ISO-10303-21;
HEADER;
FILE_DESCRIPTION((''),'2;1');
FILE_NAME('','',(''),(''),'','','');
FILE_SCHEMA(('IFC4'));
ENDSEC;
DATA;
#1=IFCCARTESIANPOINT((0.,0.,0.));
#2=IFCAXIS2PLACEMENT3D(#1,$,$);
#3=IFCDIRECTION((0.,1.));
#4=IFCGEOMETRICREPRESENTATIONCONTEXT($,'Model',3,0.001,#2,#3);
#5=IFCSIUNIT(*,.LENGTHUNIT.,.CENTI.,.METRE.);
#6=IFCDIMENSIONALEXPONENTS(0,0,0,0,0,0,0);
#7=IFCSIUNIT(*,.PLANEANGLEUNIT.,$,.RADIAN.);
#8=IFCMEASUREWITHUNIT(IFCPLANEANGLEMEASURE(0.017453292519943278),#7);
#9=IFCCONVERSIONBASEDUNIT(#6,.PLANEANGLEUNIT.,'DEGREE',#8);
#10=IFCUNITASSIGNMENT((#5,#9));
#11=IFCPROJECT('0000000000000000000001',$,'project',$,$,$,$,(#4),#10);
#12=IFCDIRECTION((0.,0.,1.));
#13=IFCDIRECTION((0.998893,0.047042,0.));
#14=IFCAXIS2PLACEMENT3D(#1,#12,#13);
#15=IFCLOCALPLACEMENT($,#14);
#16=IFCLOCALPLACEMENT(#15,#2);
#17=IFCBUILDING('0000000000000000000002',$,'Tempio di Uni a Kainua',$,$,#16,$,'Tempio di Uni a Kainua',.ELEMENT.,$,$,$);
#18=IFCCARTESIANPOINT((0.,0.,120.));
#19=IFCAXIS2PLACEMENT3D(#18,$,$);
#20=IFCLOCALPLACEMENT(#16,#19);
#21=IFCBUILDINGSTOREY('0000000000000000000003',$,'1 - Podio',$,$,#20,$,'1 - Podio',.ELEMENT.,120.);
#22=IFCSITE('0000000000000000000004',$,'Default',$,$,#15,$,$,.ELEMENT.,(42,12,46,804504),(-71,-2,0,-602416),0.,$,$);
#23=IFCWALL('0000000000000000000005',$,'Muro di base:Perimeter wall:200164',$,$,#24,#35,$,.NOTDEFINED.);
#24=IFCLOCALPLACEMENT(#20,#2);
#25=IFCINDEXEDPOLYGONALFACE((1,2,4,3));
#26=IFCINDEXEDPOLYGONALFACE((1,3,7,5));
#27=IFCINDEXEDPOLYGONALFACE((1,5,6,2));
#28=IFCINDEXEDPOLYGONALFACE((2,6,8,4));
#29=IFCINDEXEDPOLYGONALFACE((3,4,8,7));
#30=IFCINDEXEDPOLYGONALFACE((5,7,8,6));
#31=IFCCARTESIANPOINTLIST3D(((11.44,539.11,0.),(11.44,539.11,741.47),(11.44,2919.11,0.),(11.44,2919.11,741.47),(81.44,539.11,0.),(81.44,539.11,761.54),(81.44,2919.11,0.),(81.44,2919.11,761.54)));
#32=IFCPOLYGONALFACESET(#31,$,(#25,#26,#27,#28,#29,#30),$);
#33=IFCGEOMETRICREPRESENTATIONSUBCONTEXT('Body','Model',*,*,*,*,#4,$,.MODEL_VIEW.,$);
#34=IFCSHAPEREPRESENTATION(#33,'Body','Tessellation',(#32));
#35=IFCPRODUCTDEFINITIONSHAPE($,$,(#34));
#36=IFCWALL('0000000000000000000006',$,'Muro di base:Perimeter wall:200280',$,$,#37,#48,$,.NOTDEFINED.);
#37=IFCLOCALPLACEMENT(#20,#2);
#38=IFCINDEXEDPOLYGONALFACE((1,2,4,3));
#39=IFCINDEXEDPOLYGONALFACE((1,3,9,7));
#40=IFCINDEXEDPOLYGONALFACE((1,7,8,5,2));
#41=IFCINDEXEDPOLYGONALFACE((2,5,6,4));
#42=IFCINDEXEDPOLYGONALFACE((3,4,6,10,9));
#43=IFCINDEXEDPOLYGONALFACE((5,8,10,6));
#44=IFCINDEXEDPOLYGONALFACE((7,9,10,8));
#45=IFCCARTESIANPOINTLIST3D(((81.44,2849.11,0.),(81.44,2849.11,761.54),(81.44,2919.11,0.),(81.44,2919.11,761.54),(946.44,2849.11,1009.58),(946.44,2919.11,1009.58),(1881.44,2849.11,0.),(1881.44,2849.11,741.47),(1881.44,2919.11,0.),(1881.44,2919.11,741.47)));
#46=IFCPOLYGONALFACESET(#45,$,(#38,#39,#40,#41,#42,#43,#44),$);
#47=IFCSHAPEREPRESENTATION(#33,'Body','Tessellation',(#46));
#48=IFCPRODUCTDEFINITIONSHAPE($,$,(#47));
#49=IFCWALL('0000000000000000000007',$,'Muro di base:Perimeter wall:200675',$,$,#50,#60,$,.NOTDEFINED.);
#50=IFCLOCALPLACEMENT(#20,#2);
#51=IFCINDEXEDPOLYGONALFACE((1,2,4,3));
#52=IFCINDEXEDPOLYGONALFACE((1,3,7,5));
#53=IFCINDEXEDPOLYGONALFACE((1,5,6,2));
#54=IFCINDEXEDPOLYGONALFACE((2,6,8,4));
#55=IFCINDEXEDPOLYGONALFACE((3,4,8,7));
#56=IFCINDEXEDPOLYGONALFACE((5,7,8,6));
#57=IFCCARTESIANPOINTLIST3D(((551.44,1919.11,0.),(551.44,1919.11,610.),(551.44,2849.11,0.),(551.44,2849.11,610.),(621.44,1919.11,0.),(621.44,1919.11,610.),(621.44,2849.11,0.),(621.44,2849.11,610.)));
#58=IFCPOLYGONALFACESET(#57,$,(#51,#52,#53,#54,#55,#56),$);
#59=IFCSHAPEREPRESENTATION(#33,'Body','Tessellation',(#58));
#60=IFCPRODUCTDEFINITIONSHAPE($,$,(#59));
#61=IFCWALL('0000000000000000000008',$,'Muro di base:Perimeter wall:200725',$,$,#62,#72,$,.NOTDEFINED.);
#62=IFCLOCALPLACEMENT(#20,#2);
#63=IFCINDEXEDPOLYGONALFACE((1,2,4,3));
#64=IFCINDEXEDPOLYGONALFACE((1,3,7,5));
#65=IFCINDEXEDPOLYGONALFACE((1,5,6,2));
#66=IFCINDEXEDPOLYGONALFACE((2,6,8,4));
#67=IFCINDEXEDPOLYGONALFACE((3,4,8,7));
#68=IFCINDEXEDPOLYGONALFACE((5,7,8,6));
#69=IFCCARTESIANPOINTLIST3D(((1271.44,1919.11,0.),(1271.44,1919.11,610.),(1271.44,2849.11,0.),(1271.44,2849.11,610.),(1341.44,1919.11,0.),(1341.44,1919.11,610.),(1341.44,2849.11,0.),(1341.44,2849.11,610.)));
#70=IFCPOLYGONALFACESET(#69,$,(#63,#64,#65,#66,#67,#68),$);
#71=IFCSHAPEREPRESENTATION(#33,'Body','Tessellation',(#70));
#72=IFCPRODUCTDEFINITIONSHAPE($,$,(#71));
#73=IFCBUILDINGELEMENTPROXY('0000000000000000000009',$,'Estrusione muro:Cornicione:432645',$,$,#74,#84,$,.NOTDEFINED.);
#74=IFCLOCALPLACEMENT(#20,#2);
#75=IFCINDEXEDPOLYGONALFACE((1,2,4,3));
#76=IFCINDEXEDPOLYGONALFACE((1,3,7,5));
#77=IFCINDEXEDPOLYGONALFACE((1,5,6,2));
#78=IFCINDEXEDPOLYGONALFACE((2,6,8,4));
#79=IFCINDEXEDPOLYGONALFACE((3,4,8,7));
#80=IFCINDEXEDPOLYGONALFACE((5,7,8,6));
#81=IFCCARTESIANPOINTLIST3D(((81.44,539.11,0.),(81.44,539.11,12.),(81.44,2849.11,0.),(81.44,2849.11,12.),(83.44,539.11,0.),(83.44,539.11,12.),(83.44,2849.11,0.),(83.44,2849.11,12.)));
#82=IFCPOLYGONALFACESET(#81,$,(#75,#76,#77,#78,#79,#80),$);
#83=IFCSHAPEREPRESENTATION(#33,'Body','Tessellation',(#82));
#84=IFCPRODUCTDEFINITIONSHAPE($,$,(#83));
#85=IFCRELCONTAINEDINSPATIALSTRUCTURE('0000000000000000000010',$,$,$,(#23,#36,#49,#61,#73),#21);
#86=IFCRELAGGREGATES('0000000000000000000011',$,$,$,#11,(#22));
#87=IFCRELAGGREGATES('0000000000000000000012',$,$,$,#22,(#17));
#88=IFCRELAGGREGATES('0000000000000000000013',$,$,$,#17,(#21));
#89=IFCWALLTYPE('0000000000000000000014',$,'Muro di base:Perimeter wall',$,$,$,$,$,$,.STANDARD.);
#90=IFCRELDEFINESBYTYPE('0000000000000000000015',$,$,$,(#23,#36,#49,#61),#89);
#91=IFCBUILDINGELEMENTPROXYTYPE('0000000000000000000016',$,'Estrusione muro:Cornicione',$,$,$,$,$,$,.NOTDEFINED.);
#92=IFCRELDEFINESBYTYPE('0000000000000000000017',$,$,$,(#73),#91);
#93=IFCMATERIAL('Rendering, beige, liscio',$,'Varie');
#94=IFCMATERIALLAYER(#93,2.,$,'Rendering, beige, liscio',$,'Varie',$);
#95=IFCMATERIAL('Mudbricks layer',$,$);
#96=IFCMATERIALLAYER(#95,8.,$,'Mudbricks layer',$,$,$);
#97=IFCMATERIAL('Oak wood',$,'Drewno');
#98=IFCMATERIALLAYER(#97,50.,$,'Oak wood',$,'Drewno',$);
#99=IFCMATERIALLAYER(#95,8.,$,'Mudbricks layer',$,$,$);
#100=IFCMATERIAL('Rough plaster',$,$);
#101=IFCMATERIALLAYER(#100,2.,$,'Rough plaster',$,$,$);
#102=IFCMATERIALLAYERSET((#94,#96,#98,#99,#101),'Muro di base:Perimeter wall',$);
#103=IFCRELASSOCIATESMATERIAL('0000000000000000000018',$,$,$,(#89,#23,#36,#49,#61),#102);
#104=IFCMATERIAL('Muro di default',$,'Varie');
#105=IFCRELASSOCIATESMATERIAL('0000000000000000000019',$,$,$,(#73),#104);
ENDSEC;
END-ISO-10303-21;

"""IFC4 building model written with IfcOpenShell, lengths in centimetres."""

from ifc_helpers import new_model, entity, si_unit, converted_unit, direction, frame, frame_2d, origin, origin_2d_with_axis, place, context, subcontext, project, spatial, polyline, rectangle, extrude, clip, bounded_halfspace, material, layer, layer_set, layer_usage, type_object, element, save


model = new_model("IFC4")

# Units and contexts
model_context = context("Model", 3, precision=0.001, world=origin(), true_north=direction((0.0, 1.0)))
body_context = subcontext(model_context, "Body", "Model", "MODEL_VIEW")
ifc_project = project(units=[si_unit("LENGTHUNIT", "METRE", prefix="CENTI"), converted_unit("PLANEANGLEUNIT", "DEGREE", entity("IfcPlaneAngleMeasure", 0.017453292519943278), si_unit("PLANEANGLEUNIT", "RADIAN"), dimensions=[0, 0, 0, 0, 0, 0, 0])], contexts=[model_context])

# Site, building, storey
site_placement = place(None, frame((0.0, 0.0, 0.0), z_axis=(0.0, 0.0, 1.0), x_axis=(0.998893, 0.047042, 0.0)))
site = spatial("IfcSite", under=ifc_project, at=site_placement, Name="Default", CompositionType="ELEMENT", RefLatitude=(42, 12, 46, 804504), RefLongitude=(-71, -2, 0, -602416), RefElevation=0.0)
building_placement = place(site_placement, origin())
building = spatial("IfcBuilding", under=site, at=building_placement, Name="Tempio di Uni a Kainua", LongName="Tempio di Uni a Kainua", CompositionType="ELEMENT")
storey_placement = place(building_placement, frame((0.0, 0.0, 120.0)))
storey = spatial("IfcBuildingStorey", under=building, at=storey_placement, Name="1 - Podio", LongName="1 - Podio", CompositionType="ELEMENT", Elevation=120.0)

# Walls
ifc_material_1 = material(Name="Rendering, beige, liscio", Category="Varie")
ifc_layer_1 = layer(ifc_material_1, 2.0, Name="Rendering, beige, liscio", Category="Varie")
ifc_material_2 = material(Name="Mudbricks layer")
ifc_layer_2 = layer(ifc_material_2, 8.0, Name="Mudbricks layer")
ifc_material_3 = material(Name="Oak wood", Category="Drewno")
ifc_layer_3 = layer(ifc_material_3, 50.0, Name="Oak wood", Category="Drewno")
ifc_layer_4 = layer(ifc_material_2, 8.0, Name="Mudbricks layer")
ifc_material_4 = material(Name="Rough plaster")
ifc_layer_5 = layer(ifc_material_4, 2.0, Name="Rough plaster")
ifc_layer_set_1 = layer_set([ifc_layer_1, ifc_layer_2, ifc_layer_3, ifc_layer_4, ifc_layer_5], Name="Muro di base:Perimeter wall")
ifc_layer_usage_1 = layer_usage(ifc_layer_set_1, "AXIS2", "NEGATIVE", 35.0)
wall_type = type_object("IfcWallType", Name="Muro di base:Perimeter wall", PredefinedType="STANDARD", material=ifc_layer_set_1)
wall_1_placement = place(storey_placement, frame((46.44, 539.11, 0.0), z_axis=(0.0, 0.0, 1.0), x_axis=(0.0, 1.0, 0.0)))
element("IfcWall", 1, at=wall_1_placement, inside=storey, type_object=wall_type, material=ifc_layer_usage_1, Name="Muro di base:Perimeter wall:200164", PredefinedType="NOTDEFINED", context=body_context, shape_type="Clipping", body=[
    clip(extrude(rectangle(XDim=2380.0, YDim=70.0, at=frame_2d((1190.0, 0.0), x_axis=(-1.0, 0.0))), origin(), (0.0, 0.0, 1.0), 761.54), bounded_halfspace(frame((0.0, -35.0, 761.54), z_axis=(0.0, -0.275637, -0.961262), x_axis=(-1.0, 0.0, 0.0)), True, frame((0.0, -35.0, 761.54)), polyline([(0.0, 0.0), (2310.0, 0.0), (2380.0, 0.0), (2380.0, 70.0), (0.0, 70.0), (0.0, 0.0)]))),
])
ifc_layer_usage_2 = layer_usage(ifc_layer_set_1, "AXIS2", "NEGATIVE", 35.0)
wall_2_placement = place(storey_placement, frame((81.44, 2884.11, 0.0)))
element("IfcWall", 2, at=wall_2_placement, inside=storey, type_object=wall_type, material=ifc_layer_usage_2, Name="Muro di base:Perimeter wall:200280", PredefinedType="NOTDEFINED", context=body_context, shape_type="Clipping", body=[
    clip(clip(extrude(rectangle(XDim=1800.0, YDim=70.0, at=frame_2d((900.0, 0.0), x_axis=(-1.0, 0.0))), origin(), (0.0, 0.0, 1.0), 1009.58), bounded_halfspace(frame((865.0, -35.0, 1009.58), z_axis=(-0.275637, 0.0, -0.961262), x_axis=(0.0, 1.0, 0.0)), True, frame((865.0, -35.0, 1009.58)), polyline([(0.0, 0.0), (865.0, 0.0), (935.0, 0.0), (935.0, 70.0), (0.0, 70.0), (0.0, 0.0)]))), bounded_halfspace(frame((0.0, -35.0, 761.54), z_axis=(0.275637, 0.0, -0.961262), x_axis=(0.0, -1.0, 0.0)), True, frame((0.0, -35.0, 761.54)), polyline([(0.0, 0.0), (865.0, 0.0), (865.0, 70.0), (0.0, 70.0), (0.0, 0.0)]))),
])
ifc_layer_usage_3 = layer_usage(ifc_layer_set_1, "AXIS2", "NEGATIVE", 35.0)
wall_3_placement = place(storey_placement, frame((586.44, 1919.11, 0.0), z_axis=(0.0, 0.0, 1.0), x_axis=(0.0, 1.0, 0.0)))
element("IfcWall", 3, at=wall_3_placement, inside=storey, type_object=wall_type, material=ifc_layer_usage_3, Name="Muro di base:Perimeter wall:200675", PredefinedType="NOTDEFINED", context=body_context, shape_type="SweptSolid", body=[
    extrude(rectangle(XDim=930.0, YDim=70.0, at=frame_2d((465.0, 0.0), x_axis=(-1.0, 0.0))), origin(), (0.0, 0.0, 1.0), 610.0),
])
ifc_layer_usage_4 = layer_usage(ifc_layer_set_1, "AXIS2", "NEGATIVE", 35.0)
wall_4_placement = place(storey_placement, frame((1306.44, 1919.11, 0.0), z_axis=(0.0, 0.0, 1.0), x_axis=(0.0, 1.0, 0.0)))
element("IfcWall", 4, at=wall_4_placement, inside=storey, type_object=wall_type, material=ifc_layer_usage_4, Name="Muro di base:Perimeter wall:200725", PredefinedType="NOTDEFINED", context=body_context, shape_type="SweptSolid", body=[
    extrude(rectangle(XDim=930.0, YDim=70.0, at=frame_2d((465.0, 0.0), x_axis=(-1.0, 0.0))), origin(), (0.0, 0.0, 1.0), 610.0),
])

# Building element proxy
ifc_material_5 = material(Name="Muro di default", Category="Varie")
building_element_proxy_type = type_object("IfcBuildingElementProxyType", Name="Estrusione muro:Cornicione", PredefinedType="NOTDEFINED")
proxy_1_placement = place(storey_placement, frame((81.44, 539.11, 0.0)))
element("IfcBuildingElementProxy", 5, at=proxy_1_placement, inside=storey, type_object=building_element_proxy_type, material=ifc_material_5, Name="Estrusione muro:Cornicione:432645", PredefinedType="NOTDEFINED", context=body_context, shape_type="SweptSolid", body=[
    extrude(rectangle(XDim=2310.0, YDim=2.0, at=origin_2d_with_axis()), frame((1.0, 1155.0, 0.0), z_axis=(0.0, 0.0, 1.0), x_axis=(0.0, 1.0, 0.0)), (0.0, 0.0, 1.0), 12.0),
])

save(model, "model.ifc")
